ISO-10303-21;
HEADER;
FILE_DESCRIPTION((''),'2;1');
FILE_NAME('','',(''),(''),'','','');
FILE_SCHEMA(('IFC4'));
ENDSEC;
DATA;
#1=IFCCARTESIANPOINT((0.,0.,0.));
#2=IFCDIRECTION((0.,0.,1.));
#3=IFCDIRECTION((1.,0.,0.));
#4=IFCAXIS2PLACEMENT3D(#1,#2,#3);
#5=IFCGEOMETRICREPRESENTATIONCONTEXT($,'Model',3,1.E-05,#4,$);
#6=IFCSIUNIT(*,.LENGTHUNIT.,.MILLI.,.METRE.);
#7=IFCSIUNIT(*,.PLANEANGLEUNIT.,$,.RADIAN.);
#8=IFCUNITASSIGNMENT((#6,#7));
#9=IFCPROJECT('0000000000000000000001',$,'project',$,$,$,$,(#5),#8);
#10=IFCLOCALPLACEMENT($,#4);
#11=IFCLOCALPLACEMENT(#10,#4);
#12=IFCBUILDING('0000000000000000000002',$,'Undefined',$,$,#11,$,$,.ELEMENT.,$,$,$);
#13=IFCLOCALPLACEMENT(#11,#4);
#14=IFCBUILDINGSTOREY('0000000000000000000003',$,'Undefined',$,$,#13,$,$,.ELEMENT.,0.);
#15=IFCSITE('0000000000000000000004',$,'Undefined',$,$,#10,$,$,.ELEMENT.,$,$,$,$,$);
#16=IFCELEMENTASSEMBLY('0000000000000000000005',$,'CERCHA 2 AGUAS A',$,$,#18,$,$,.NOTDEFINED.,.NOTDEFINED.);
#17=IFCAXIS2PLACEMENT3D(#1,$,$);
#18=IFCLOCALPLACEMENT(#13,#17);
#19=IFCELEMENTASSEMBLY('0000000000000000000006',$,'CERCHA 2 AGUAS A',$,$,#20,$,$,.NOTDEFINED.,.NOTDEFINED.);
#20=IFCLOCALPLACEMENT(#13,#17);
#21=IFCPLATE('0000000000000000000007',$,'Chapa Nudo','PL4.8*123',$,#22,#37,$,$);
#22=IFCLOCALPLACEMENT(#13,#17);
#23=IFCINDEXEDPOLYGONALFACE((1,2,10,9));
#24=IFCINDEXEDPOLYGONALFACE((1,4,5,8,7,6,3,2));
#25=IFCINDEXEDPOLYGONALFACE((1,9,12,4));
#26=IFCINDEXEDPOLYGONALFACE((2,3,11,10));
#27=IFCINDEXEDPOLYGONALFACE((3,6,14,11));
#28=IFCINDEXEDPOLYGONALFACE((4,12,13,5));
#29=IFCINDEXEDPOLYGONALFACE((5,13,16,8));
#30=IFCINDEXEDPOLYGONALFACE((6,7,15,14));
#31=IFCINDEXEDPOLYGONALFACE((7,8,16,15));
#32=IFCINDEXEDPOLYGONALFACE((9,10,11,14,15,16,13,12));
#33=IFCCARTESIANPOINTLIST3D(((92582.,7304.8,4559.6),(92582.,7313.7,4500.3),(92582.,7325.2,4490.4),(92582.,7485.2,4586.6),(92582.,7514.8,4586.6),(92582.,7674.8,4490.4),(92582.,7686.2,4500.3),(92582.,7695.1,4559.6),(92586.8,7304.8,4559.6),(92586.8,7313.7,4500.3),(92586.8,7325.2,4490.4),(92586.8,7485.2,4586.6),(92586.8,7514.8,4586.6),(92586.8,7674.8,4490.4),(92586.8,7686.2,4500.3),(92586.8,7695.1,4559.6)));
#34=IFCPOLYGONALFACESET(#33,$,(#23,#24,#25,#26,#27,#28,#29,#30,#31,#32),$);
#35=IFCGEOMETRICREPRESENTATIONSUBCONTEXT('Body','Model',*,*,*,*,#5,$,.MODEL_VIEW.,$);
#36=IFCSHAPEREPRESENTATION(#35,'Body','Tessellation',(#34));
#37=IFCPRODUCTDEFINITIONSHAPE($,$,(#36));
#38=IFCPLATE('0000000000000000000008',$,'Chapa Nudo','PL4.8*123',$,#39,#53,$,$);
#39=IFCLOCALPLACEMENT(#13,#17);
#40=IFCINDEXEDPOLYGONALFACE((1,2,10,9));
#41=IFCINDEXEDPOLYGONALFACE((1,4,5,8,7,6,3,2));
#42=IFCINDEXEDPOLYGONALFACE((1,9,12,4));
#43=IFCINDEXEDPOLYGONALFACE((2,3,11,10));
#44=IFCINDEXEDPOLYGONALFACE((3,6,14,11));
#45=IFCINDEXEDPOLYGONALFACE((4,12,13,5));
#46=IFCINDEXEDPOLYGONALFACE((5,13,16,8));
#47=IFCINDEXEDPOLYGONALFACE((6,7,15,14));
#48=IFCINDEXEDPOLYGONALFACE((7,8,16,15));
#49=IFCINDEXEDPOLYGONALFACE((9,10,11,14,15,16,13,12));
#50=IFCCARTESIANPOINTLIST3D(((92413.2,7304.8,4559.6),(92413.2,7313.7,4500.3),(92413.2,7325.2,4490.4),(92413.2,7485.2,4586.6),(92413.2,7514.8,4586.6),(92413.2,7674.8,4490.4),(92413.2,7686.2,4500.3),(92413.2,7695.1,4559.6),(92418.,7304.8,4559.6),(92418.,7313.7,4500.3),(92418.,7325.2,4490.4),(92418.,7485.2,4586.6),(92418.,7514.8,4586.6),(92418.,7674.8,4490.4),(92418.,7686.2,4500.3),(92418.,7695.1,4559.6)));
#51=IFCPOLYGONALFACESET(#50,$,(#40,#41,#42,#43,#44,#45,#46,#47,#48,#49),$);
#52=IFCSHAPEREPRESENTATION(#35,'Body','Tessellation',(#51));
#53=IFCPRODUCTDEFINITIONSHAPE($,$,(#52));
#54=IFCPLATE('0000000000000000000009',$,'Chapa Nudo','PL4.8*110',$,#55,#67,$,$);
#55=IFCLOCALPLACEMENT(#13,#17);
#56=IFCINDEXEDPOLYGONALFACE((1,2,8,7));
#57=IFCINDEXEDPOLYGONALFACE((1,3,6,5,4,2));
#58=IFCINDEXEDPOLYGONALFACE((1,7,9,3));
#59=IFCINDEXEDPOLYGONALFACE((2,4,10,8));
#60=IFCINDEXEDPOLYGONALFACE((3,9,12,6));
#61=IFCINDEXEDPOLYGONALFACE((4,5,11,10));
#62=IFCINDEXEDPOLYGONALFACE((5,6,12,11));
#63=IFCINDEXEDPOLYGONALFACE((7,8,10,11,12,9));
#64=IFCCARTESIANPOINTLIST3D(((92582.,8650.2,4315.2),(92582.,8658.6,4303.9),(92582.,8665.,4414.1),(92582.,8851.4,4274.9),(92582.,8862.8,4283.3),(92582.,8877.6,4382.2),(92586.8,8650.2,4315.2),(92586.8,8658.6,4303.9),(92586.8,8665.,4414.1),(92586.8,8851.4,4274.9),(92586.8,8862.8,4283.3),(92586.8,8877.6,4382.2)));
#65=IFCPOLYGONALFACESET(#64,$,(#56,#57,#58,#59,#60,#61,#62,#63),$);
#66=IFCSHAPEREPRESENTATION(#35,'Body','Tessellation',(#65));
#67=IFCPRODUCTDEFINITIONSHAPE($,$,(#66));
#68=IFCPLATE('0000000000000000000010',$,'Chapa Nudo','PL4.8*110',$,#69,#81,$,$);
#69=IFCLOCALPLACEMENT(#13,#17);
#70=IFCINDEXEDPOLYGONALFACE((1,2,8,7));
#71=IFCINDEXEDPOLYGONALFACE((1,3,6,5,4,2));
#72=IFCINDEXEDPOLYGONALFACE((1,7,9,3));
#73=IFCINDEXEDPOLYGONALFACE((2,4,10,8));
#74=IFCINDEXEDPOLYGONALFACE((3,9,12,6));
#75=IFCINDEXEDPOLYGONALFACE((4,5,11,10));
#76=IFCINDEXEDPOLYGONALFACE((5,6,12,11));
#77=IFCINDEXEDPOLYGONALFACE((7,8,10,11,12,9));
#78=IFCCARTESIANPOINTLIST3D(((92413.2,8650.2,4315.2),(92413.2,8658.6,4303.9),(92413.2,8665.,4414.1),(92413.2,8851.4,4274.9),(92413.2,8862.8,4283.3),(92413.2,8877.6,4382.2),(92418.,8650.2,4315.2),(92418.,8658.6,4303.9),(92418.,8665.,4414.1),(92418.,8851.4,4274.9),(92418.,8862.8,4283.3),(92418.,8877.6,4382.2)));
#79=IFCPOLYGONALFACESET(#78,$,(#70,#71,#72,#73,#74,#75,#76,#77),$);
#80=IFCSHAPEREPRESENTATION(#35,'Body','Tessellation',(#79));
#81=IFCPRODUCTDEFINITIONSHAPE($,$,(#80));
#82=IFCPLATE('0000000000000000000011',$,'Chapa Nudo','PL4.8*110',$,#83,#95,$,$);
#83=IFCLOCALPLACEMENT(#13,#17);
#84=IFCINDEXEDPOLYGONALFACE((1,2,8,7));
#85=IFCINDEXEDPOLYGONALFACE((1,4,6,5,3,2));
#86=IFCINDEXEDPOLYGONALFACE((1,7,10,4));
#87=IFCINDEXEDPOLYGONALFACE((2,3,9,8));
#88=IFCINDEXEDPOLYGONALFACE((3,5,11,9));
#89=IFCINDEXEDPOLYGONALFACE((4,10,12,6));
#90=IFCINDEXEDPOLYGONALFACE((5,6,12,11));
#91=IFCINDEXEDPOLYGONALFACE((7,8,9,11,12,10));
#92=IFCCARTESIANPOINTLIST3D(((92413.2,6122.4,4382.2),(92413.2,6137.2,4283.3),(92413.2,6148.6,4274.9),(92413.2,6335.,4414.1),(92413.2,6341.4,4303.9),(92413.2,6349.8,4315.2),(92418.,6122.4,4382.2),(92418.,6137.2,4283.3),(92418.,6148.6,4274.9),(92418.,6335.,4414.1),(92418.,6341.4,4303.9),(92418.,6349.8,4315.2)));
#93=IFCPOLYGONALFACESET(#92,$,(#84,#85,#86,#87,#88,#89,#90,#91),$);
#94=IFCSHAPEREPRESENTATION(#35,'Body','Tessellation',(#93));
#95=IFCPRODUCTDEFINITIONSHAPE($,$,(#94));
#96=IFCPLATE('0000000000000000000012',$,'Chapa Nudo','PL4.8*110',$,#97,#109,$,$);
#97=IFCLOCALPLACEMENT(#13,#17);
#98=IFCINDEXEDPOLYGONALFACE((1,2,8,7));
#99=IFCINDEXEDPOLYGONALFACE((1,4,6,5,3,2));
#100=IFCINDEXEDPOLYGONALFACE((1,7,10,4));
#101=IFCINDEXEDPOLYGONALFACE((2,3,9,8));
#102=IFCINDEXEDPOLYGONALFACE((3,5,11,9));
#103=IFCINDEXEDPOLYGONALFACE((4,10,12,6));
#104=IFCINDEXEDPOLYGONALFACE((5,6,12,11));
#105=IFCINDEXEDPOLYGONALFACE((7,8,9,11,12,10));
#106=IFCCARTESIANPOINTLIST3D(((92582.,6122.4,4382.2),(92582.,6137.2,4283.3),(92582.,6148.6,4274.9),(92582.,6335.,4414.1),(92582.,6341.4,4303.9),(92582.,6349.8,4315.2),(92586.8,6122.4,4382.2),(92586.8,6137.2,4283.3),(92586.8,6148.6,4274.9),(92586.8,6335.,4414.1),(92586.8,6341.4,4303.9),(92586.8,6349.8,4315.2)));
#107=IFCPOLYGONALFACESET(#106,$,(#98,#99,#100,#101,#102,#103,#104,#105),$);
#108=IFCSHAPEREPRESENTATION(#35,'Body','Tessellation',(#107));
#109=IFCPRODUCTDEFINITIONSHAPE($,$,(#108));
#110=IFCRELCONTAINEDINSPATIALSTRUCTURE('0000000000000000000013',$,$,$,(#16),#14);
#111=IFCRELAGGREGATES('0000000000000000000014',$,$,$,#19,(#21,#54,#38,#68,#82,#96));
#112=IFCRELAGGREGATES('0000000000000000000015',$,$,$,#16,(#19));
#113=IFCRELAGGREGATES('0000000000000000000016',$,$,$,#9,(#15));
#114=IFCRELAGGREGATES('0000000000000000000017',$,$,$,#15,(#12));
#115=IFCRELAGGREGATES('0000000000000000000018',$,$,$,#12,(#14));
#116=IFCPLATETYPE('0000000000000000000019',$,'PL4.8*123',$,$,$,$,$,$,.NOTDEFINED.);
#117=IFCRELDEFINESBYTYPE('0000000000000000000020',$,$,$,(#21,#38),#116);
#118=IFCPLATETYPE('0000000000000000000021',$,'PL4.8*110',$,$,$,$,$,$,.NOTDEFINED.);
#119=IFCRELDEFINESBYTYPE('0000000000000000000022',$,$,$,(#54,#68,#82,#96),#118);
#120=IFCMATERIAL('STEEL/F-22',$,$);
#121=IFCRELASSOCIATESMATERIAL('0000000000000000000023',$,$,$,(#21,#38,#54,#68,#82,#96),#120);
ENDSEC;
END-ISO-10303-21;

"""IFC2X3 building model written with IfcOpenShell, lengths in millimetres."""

from ifc_helpers import new_model, si_unit, frame, origin_with_axes, place, context, subcontext, project, spatial, polyline, outline, extrude, material, type_object, element, aggregate, save


model = new_model("IFC2X3")

# Units and contexts
model_context = context("Model", 3, precision=1e-05, world=origin_with_axes())
body_context = subcontext(model_context, "Body", "Model", "MODEL_VIEW")
ifc_project = project(units=[si_unit("LENGTHUNIT", "METRE", prefix="MILLI"), si_unit("PLANEANGLEUNIT", "RADIAN")], contexts=[model_context])

# Site, building, storey
site_placement = place(None, origin_with_axes())
site = spatial("IfcSite", under=ifc_project, at=site_placement, Name="Undefined", CompositionType="ELEMENT")
building_placement = place(site_placement, origin_with_axes())
building = spatial("IfcBuilding", under=site, at=building_placement, Name="Undefined", CompositionType="ELEMENT")
storey_placement = place(building_placement, origin_with_axes())
storey = spatial("IfcBuildingStorey", under=building, at=storey_placement, Name="Undefined", CompositionType="ELEMENT", Elevation=0.0)

# Shared definitions
ifc_material_1 = material(Name="STEEL/F-22")

# Element assemblies
assembly_1_placement = place(storey_placement, origin_with_axes())
assembly_1 = element("IfcElementAssembly", 1, at=assembly_1_placement, inside=storey, Name="CERCHA 2 AGUAS A", AssemblyPlace="NOTDEFINED", PredefinedType="NOTDEFINED")
assembly_2_placement = place(assembly_1_placement, origin_with_axes())
assembly_2 = element("IfcElementAssembly", 2, at=assembly_2_placement, Name="CERCHA 2 AGUAS A", AssemblyPlace="NOTDEFINED", PredefinedType="NOTDEFINED")

# Plates
plate_type_1 = type_object("IfcPlateType", Name="PL4.8*123", PredefinedType="NOTDEFINED")
plate_1_placement = place(assembly_2_placement, frame((92584.4, 7695.1, 4559.6), z_axis=(-1.0, 0.0, 0.0), x_axis=(0.0, -0.148335, -0.988937)))
plate_1 = element("IfcPlate", 3, at=plate_1_placement, type_object=plate_type_1, material=ifc_material_1, Name="Chapa Nudo", Description="PL4.8*123", context=body_context, shape_type="SweptSolid", body=[
    extrude(outline(polyline([(0.0, 0.0), (60.0, 0.0), (71.5, 9.9), (123.3, 355.6), (115.3, 368.4), (57.9, 386.0), (4.4, 211.7), (0.0, 182.3), (0.0, 0.0)])), frame((0.0, 0.0, -2.4), z_axis=(0.0, 0.0, 1.0), x_axis=(1.0, 0.0, 0.0)), (0.0, 0.0, 1.0), 4.8),
])
plate_2_placement = place(assembly_2_placement, frame((92415.6, 7695.1, 4559.6), z_axis=(-1.0, 0.0, 0.0), x_axis=(0.0, -0.148335, -0.988937)))
plate_2 = element("IfcPlate", 4, at=plate_2_placement, type_object=plate_type_1, material=ifc_material_1, Name="Chapa Nudo", Description="PL4.8*123", context=body_context, shape_type="SweptSolid", body=[
    extrude(outline(polyline([(0.0, 0.0), (60.0, 0.0), (71.5, 9.9), (123.3, 355.6), (115.3, 368.4), (57.9, 386.0), (4.4, 211.7), (0.0, 182.3), (0.0, 0.0)])), frame((0.0, 0.0, -2.4), z_axis=(0.0, 0.0, 1.0), x_axis=(1.0, 0.0, 0.0)), (0.0, 0.0, 1.0), 4.8),
])
plate_type_2 = type_object("IfcPlateType", Name="PL4.8*110", PredefinedType="NOTDEFINED")
plate_3_placement = place(assembly_2_placement, frame((92584.4, 8877.6, 4382.2), z_axis=(-1.0, 0.0, 0.0), x_axis=(0.0, -0.148335, -0.988937)))
plate_3 = element("IfcPlate", 5, at=plate_3_placement, type_object=plate_type_2, material=ifc_material_1, Name="Chapa Nudo", Description="PL4.8*110", context=body_context, shape_type="SweptSolid", body=[
    extrude(outline(polyline([(0.0, 0.0), (100.0, 0.0), (110.0, 10.0), (110.0, 205.0), (100.0, 215.0), (0.0, 215.0), (0.0, 0.0)])), frame((0.0, 0.0, -2.4), z_axis=(0.0, 0.0, 1.0), x_axis=(1.0, 0.0, 0.0)), (0.0, 0.0, 1.0), 4.8),
])
plate_4_placement = place(assembly_2_placement, frame((92415.6, 8877.6, 4382.2), z_axis=(-1.0, 0.0, 0.0), x_axis=(0.0, -0.148335, -0.988937)))
plate_4 = element("IfcPlate", 6, at=plate_4_placement, type_object=plate_type_2, material=ifc_material_1, Name="Chapa Nudo", Description="PL4.8*110", context=body_context, shape_type="SweptSolid", body=[
    extrude(outline(polyline([(0.0, 0.0), (100.0, 0.0), (110.0, 10.0), (110.0, 205.0), (100.0, 215.0), (0.0, 215.0), (0.0, 0.0)])), frame((0.0, 0.0, -2.4), z_axis=(0.0, 0.0, 1.0), x_axis=(1.0, 0.0, 0.0)), (0.0, 0.0, 1.0), 4.8),
])
plate_5_placement = place(assembly_2_placement, frame((92415.6, 6122.4, 4382.2), z_axis=(1.0, 0.0, 0.0), x_axis=(0.0, 0.148335, -0.988937)))
plate_5 = element("IfcPlate", 7, at=plate_5_placement, type_object=plate_type_2, material=ifc_material_1, Name="Chapa Nudo", Description="PL4.8*110", context=body_context, shape_type="SweptSolid", body=[
    extrude(outline(polyline([(0.0, 0.0), (100.0, 0.0), (110.0, 10.0), (110.0, 205.0), (100.0, 215.0), (0.0, 215.0), (0.0, 0.0)])), frame((0.0, 0.0, -2.4), z_axis=(0.0, 0.0, 1.0), x_axis=(1.0, 0.0, 0.0)), (0.0, 0.0, 1.0), 4.8),
])
plate_6_placement = place(assembly_2_placement, frame((92584.4, 6122.4, 4382.2), z_axis=(1.0, 0.0, 0.0), x_axis=(0.0, 0.148335, -0.988937)))
plate_6 = element("IfcPlate", 8, at=plate_6_placement, type_object=plate_type_2, material=ifc_material_1, Name="Chapa Nudo", Description="PL4.8*110", context=body_context, shape_type="SweptSolid", body=[
    extrude(outline(polyline([(0.0, 0.0), (100.0, 0.0), (110.0, 10.0), (110.0, 205.0), (100.0, 215.0), (0.0, 215.0), (0.0, 0.0)])), frame((0.0, 0.0, -2.4), z_axis=(0.0, 0.0, 1.0), x_axis=(1.0, 0.0, 0.0)), (0.0, 0.0, 1.0), 4.8),
])

aggregate(assembly_2, [plate_1, plate_3, plate_2, plate_4, plate_5, plate_6])
aggregate(assembly_1, [assembly_2])

save(model, "model.ifc")
